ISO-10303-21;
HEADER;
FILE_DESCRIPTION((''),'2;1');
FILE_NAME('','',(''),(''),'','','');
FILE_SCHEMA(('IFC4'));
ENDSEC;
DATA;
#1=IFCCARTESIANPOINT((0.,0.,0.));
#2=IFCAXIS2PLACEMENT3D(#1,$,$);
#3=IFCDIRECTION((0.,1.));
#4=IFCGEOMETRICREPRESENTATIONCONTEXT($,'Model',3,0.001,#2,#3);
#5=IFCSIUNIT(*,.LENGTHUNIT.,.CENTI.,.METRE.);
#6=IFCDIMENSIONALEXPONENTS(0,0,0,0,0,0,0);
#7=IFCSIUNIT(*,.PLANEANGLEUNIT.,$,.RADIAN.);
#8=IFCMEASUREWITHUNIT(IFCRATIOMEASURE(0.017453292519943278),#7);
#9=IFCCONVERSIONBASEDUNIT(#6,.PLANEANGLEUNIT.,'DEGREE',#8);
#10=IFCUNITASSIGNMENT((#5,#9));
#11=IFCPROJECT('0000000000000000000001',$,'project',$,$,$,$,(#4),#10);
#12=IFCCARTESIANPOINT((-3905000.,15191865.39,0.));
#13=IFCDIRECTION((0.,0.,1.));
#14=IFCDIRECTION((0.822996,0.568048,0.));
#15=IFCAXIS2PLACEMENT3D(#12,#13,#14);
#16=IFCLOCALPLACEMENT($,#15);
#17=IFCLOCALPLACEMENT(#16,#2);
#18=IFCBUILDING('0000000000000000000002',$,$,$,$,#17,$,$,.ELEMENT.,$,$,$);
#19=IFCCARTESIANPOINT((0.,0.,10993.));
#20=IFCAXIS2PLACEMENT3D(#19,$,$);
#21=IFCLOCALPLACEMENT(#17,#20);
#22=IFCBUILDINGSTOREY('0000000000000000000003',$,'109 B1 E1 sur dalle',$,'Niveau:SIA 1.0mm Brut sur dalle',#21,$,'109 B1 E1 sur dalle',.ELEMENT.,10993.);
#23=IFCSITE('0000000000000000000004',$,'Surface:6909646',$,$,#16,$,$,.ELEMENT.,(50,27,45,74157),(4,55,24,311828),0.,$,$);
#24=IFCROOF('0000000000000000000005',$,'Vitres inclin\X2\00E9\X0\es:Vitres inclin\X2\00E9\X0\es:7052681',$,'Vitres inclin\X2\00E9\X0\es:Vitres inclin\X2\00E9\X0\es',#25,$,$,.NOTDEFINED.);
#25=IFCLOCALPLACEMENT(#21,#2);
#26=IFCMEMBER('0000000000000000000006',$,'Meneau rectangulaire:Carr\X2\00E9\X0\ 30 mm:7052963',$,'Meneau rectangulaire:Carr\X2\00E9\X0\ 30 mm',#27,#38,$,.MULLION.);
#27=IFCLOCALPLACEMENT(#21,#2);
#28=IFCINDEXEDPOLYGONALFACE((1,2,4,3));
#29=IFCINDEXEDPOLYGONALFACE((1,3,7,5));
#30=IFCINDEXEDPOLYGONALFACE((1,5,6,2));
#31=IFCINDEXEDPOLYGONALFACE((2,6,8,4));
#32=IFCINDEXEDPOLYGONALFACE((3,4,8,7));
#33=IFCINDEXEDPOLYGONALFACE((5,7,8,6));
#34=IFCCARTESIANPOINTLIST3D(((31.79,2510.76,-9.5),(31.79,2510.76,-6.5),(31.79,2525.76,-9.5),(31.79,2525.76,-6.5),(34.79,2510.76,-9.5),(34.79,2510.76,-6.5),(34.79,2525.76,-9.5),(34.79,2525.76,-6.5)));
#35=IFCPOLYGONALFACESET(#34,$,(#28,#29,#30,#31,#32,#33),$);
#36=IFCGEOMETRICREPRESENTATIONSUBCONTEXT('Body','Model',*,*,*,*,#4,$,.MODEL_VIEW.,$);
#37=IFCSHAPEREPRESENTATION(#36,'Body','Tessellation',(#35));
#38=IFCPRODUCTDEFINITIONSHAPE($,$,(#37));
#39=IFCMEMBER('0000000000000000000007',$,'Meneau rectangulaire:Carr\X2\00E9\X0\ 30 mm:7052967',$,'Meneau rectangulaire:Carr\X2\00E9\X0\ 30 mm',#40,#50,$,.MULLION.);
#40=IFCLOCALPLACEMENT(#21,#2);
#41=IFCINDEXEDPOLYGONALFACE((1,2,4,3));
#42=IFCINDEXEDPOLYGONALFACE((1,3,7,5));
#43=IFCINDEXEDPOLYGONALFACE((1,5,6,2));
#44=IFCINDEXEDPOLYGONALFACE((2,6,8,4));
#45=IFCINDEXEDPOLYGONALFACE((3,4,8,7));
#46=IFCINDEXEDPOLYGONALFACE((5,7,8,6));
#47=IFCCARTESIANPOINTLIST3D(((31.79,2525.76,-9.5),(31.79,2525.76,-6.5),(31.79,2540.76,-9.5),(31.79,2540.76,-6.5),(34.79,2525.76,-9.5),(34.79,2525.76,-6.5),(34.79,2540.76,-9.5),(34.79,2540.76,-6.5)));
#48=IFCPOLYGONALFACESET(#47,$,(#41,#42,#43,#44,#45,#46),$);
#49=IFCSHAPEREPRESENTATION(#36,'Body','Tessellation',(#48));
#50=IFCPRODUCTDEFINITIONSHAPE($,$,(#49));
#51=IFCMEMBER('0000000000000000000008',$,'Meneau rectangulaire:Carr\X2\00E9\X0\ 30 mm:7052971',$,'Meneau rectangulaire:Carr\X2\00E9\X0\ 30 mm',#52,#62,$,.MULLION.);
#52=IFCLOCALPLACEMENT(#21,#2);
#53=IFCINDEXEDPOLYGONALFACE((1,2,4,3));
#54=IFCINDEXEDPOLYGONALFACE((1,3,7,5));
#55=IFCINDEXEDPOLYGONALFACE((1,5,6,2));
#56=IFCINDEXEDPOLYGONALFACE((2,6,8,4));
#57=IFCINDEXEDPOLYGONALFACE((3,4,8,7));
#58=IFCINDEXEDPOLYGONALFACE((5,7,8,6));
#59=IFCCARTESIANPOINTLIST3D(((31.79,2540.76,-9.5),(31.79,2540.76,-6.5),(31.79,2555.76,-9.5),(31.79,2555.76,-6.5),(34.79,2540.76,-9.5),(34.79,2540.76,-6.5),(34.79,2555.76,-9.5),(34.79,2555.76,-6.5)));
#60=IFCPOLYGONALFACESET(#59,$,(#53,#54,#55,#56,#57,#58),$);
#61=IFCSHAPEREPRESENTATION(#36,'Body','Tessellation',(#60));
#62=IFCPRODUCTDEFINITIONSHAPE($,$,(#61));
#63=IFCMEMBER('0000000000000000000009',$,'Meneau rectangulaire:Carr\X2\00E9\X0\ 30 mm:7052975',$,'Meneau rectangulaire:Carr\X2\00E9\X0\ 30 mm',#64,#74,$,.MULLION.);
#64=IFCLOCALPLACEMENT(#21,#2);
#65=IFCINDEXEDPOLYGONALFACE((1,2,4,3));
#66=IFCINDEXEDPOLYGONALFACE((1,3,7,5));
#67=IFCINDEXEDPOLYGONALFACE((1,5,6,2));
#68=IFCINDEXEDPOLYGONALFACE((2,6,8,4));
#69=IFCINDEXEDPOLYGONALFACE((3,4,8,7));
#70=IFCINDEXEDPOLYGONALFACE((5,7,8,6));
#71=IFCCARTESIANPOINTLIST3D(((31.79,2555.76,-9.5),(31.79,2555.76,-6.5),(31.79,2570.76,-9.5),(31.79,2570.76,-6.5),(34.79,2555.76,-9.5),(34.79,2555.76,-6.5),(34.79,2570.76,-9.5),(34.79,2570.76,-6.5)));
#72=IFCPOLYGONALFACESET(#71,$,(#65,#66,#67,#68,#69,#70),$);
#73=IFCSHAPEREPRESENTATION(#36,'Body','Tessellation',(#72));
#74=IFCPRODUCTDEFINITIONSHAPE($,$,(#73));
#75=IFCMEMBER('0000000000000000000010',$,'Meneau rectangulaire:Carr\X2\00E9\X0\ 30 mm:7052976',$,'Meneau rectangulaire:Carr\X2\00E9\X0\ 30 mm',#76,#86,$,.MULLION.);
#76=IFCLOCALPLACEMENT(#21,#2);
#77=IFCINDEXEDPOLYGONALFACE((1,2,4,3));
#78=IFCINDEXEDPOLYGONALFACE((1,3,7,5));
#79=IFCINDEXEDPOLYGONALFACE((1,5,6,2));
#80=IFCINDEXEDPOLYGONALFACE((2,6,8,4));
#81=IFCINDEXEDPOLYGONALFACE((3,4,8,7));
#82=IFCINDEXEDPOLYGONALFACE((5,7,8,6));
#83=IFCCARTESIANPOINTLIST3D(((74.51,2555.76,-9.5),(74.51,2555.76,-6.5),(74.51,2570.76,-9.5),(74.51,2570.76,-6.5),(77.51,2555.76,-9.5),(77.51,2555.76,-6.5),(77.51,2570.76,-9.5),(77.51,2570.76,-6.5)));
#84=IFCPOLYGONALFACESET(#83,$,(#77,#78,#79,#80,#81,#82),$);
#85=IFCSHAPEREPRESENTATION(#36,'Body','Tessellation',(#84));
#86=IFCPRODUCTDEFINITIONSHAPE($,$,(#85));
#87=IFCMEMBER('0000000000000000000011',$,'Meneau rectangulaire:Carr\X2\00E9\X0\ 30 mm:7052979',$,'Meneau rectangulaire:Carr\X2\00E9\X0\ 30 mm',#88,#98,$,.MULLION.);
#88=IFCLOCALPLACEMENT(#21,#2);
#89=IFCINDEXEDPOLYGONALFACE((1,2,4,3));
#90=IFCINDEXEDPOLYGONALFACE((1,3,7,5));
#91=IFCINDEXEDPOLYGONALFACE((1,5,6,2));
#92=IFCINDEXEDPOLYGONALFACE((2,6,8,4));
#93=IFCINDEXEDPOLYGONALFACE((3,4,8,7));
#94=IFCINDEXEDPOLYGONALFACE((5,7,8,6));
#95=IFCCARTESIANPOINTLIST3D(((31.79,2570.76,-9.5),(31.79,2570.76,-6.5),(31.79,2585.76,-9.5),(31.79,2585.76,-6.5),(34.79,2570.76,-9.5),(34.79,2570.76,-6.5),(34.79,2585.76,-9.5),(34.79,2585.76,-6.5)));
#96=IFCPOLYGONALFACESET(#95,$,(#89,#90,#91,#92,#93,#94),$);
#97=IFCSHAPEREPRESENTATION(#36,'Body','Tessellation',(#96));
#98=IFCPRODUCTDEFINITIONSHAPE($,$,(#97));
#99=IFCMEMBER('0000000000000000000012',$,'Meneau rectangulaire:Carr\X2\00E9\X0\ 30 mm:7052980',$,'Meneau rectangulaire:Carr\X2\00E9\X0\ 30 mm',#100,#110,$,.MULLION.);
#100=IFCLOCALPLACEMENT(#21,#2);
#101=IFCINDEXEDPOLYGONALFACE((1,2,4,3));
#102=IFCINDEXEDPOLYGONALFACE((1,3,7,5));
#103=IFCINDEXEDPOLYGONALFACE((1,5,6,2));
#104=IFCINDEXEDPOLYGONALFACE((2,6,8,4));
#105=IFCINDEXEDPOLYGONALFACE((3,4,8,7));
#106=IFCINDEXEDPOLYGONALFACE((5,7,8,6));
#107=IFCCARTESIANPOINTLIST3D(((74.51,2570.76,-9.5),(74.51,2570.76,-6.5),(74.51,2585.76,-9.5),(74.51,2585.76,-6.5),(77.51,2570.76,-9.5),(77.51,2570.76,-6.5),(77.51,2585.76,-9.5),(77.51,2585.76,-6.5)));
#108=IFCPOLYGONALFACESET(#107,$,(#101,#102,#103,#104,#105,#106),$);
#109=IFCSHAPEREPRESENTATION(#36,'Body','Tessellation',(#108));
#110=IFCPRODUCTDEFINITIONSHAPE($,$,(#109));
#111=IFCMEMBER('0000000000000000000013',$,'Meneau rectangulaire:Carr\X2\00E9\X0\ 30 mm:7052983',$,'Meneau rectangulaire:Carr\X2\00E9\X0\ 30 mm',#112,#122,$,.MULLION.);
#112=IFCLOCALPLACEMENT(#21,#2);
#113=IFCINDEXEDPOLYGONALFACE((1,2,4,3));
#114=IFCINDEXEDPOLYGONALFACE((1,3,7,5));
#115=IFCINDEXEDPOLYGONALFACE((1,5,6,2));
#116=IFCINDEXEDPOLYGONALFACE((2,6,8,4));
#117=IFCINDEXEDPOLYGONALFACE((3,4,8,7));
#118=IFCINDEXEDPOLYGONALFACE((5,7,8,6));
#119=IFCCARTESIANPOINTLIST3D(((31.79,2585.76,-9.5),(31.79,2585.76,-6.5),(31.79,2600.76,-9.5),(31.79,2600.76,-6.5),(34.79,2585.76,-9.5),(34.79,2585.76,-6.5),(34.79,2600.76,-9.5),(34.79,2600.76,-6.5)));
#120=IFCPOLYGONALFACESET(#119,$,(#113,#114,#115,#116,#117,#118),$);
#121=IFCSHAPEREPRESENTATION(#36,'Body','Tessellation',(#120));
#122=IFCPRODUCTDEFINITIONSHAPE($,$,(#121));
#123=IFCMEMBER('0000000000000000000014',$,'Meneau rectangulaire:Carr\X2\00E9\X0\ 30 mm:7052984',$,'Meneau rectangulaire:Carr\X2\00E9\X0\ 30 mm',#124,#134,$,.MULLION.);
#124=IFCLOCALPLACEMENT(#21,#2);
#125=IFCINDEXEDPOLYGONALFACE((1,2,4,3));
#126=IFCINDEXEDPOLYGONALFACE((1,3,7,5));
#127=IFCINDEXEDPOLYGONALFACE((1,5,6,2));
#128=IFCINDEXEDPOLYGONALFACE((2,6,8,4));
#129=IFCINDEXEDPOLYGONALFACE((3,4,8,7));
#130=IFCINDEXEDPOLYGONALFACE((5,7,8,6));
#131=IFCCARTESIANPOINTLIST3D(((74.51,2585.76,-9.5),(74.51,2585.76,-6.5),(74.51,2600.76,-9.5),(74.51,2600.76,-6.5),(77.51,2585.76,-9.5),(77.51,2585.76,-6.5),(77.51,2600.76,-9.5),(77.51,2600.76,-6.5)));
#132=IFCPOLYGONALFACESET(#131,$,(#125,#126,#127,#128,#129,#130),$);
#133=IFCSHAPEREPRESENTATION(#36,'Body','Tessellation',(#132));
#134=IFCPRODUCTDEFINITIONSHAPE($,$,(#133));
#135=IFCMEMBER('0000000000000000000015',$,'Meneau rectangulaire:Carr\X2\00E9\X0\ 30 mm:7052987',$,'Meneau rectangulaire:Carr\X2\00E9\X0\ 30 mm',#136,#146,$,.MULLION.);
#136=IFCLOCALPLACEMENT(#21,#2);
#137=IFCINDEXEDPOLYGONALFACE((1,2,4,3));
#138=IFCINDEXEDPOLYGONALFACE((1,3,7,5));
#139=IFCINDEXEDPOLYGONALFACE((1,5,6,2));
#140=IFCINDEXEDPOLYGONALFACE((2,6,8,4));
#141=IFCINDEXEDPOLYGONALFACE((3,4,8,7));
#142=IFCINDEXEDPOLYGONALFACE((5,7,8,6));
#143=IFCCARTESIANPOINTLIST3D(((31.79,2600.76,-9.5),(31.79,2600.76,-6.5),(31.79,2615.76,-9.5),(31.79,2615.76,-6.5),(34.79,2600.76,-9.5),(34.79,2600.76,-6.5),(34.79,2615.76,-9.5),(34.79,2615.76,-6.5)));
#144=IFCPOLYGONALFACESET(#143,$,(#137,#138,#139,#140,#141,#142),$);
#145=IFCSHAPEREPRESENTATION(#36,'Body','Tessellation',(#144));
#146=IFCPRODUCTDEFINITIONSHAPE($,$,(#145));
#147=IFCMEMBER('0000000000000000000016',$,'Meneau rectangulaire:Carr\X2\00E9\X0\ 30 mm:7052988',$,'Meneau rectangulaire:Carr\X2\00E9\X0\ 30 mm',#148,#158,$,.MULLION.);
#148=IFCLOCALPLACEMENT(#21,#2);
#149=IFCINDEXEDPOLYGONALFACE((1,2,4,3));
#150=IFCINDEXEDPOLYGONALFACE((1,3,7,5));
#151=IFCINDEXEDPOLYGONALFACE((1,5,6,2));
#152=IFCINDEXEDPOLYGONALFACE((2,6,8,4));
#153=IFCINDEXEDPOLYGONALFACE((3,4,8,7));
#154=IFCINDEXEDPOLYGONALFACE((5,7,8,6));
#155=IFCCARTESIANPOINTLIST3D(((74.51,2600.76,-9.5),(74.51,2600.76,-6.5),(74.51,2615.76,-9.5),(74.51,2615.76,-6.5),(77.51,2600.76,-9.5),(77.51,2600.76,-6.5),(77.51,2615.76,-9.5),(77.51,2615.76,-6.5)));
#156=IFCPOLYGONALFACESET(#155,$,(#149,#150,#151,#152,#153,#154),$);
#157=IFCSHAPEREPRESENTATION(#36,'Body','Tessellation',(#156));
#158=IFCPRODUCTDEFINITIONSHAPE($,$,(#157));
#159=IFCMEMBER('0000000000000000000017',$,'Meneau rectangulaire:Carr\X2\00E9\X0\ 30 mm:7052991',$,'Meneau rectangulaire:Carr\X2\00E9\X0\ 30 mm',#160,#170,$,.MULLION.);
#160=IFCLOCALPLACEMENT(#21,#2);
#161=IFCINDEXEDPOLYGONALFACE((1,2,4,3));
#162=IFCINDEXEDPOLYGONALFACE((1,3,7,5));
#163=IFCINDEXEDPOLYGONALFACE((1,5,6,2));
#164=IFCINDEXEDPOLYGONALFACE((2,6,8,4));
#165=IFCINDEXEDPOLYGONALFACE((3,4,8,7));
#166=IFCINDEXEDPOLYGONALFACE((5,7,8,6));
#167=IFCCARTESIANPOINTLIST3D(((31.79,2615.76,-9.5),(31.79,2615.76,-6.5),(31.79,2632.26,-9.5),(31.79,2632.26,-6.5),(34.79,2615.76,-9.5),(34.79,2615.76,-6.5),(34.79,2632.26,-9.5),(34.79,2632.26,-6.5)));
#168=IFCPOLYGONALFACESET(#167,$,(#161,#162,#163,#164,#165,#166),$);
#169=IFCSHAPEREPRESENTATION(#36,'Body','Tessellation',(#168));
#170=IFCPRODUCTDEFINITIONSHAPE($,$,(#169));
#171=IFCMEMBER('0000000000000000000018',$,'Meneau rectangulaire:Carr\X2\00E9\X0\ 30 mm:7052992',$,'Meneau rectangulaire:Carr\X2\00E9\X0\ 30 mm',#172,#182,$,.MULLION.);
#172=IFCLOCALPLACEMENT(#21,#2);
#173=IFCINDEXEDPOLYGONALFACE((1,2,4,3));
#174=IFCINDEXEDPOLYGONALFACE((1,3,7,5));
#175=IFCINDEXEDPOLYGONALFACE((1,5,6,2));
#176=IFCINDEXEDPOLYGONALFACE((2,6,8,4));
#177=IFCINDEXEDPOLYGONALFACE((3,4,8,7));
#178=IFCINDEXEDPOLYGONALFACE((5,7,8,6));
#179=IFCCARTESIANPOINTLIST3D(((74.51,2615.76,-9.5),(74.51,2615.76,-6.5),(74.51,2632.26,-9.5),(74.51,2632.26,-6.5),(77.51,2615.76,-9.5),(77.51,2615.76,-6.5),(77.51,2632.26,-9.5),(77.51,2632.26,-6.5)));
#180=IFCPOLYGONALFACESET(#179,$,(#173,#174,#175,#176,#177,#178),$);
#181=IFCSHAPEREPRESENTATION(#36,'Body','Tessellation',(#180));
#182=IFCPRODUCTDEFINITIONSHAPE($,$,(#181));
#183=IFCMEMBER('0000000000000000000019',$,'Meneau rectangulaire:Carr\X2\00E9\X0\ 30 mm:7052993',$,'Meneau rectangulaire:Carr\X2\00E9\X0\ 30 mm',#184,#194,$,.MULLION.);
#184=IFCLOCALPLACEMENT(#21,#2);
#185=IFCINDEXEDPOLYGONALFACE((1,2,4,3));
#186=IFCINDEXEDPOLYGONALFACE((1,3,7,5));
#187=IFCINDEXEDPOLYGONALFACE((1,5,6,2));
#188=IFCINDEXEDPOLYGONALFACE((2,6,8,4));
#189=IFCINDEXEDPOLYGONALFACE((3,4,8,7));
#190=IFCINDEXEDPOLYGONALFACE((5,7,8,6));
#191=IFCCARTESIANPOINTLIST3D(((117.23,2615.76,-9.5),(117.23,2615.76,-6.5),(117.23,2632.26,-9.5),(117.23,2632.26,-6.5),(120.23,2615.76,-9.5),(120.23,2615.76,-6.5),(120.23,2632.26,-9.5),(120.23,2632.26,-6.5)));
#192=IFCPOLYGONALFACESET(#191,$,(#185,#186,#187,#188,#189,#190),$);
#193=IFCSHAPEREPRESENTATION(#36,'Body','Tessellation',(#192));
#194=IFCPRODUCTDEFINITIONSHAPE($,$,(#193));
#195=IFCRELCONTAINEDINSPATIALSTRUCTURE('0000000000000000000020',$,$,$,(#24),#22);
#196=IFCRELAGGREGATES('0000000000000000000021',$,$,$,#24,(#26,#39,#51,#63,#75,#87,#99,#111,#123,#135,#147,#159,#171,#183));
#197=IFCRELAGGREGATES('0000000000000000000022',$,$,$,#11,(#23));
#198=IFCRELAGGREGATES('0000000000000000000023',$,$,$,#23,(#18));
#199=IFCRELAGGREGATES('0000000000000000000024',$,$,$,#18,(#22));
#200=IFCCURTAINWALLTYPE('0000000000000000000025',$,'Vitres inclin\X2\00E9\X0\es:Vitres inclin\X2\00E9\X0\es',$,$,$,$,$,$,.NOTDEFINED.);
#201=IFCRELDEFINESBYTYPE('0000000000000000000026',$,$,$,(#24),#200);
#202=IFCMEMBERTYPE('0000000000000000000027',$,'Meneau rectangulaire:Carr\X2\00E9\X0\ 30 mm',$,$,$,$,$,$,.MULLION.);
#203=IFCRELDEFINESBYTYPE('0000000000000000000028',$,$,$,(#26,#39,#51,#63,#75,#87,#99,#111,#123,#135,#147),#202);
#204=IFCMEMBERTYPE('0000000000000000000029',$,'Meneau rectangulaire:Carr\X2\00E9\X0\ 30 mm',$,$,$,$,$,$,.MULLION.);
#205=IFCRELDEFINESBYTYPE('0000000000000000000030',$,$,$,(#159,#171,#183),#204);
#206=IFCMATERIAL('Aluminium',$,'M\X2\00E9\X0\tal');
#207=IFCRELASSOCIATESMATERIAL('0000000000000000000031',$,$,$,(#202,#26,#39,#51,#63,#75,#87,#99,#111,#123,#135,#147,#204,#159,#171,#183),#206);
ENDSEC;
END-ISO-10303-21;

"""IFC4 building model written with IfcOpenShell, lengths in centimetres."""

from ifc_helpers import new_model, entity, si_unit, converted_unit, direction, frame, origin, place, context, subcontext, project, spatial, indexed_curve, outline, extrude, source, transform, mapped, material, type_object, type_shapes, element, aggregate, save


model = new_model("IFC4")

# Units and contexts
model_context = context("Model", 3, precision=0.001, world=origin(), true_north=direction((0.0, 1.0)))
body_context = subcontext(model_context, "Body", "Model", "MODEL_VIEW")
ifc_project = project(units=[si_unit("LENGTHUNIT", "METRE", prefix="CENTI"), converted_unit("PLANEANGLEUNIT", "DEGREE", entity("IfcRatioMeasure", 0.017453292519943278), si_unit("PLANEANGLEUNIT", "RADIAN"), dimensions=[0, 0, 0, 0, 0, 0, 0])], contexts=[model_context])

# Site, building, storey
site_placement = place(None, frame((-3905000.0, 15191865.39, 0.0), z_axis=(0.0, 0.0, 1.0), x_axis=(0.822996, 0.568048, 0.0)))
site = spatial("IfcSite", under=ifc_project, at=site_placement, Name="Surface:6909646", CompositionType="ELEMENT", RefLatitude=(50, 27, 45, 74157), RefLongitude=(4, 55, 24, 311828), RefElevation=0.0)
building_placement = place(site_placement, origin())
building = spatial("IfcBuilding", under=site, at=building_placement, CompositionType="ELEMENT")
storey_placement = place(building_placement, frame((0.0, 0.0, 10993.0)))
storey = spatial("IfcBuildingStorey", under=building, at=storey_placement, Name="109 B1 E1 sur dalle", ObjectType="Niveau:SIA 1.0mm Brut sur dalle", LongName="109 B1 E1 sur dalle", CompositionType="ELEMENT", Elevation=10993.0)

# Roof, members
curtain_wall_type = type_object("IfcCurtainWallType", Name="Vitres inclinées:Vitres inclinées", PredefinedType="NOTDEFINED")
roof_placement = place(storey_placement, frame((0.0, 0.0, -10993.0)))
roof = element("IfcRoof", 1, at=roof_placement, inside=storey, type_object=curtain_wall_type, Name="Vitres inclinées:Vitres inclinées:7052681", ObjectType="Vitres inclinées:Vitres inclinées", PredefinedType="NOTDEFINED")
ifc_material = material(Name="Aluminium", Category="Métal")
member_type_1 = type_object("IfcMemberType", Name="Meneau rectangulaire:Carré 30 mm", PredefinedType="MULLION", material=ifc_material)
shared_shape_1 = source(origin(), body_context, "Body", "SweptSolid", [
    extrude(outline(indexed_curve([(-1.5, -1.5), (1.5, -1.5), (1.5, 1.5), (-1.5, 1.5), (-1.5, -1.5)], self_intersect=False)), frame((0.0, 0.0, -15.0), z_axis=(0.0, 0.0, 1.0), x_axis=(0.0, -1.0, 0.0)), (0.0, 0.0, 1.0), 15.0),
])
type_shapes(member_type_1, [shared_shape_1])
member_1_placement = place(roof_placement, frame((33.29, 2525.76, 10985.0), z_axis=(0.0, 1.0, 0.0), x_axis=(1.0, 0.0, 0.0)))
member_1 = element("IfcMember", 2, at=member_1_placement, type_object=member_type_1, material=ifc_material, Name="Meneau rectangulaire:Carré 30 mm:7052963", ObjectType="Meneau rectangulaire:Carré 30 mm", PredefinedType="MULLION", context=body_context, shape_type="MappedRepresentation", body=[
    mapped(shared_shape_1, transform((0.0, 0.0, 0.0), scale=1.0)),
])
member_2_placement = place(roof_placement, frame((33.29, 2540.76, 10985.0), z_axis=(0.0, 1.0, 0.0), x_axis=(1.0, 0.0, 0.0)))
member_2 = element("IfcMember", 3, at=member_2_placement, type_object=member_type_1, material=ifc_material, Name="Meneau rectangulaire:Carré 30 mm:7052967", ObjectType="Meneau rectangulaire:Carré 30 mm", PredefinedType="MULLION", context=body_context, shape_type="MappedRepresentation", body=[
    mapped(shared_shape_1, transform((0.0, 0.0, 0.0), scale=1.0)),
])
member_3_placement = place(roof_placement, frame((33.29, 2555.76, 10985.0), z_axis=(0.0, 1.0, 0.0), x_axis=(1.0, 0.0, 0.0)))
member_3 = element("IfcMember", 4, at=member_3_placement, type_object=member_type_1, material=ifc_material, Name="Meneau rectangulaire:Carré 30 mm:7052971", ObjectType="Meneau rectangulaire:Carré 30 mm", PredefinedType="MULLION", context=body_context, shape_type="MappedRepresentation", body=[
    mapped(shared_shape_1, transform((0.0, 0.0, 0.0), scale=1.0)),
])
member_4_placement = place(roof_placement, frame((33.29, 2570.76, 10985.0), z_axis=(0.0, 1.0, 0.0), x_axis=(1.0, 0.0, 0.0)))
member_4 = element("IfcMember", 5, at=member_4_placement, type_object=member_type_1, material=ifc_material, Name="Meneau rectangulaire:Carré 30 mm:7052975", ObjectType="Meneau rectangulaire:Carré 30 mm", PredefinedType="MULLION", context=body_context, shape_type="MappedRepresentation", body=[
    mapped(shared_shape_1, transform((0.0, 0.0, 0.0), scale=1.0)),
])
member_5_placement = place(roof_placement, frame((76.01, 2570.76, 10985.0), z_axis=(0.0, 1.0, 0.0), x_axis=(1.0, 0.0, 0.0)))
member_5 = element("IfcMember", 6, at=member_5_placement, type_object=member_type_1, material=ifc_material, Name="Meneau rectangulaire:Carré 30 mm:7052976", ObjectType="Meneau rectangulaire:Carré 30 mm", PredefinedType="MULLION", context=body_context, shape_type="MappedRepresentation", body=[
    mapped(shared_shape_1, transform((0.0, 0.0, 0.0), scale=1.0)),
])
member_6_placement = place(roof_placement, frame((33.29, 2585.76, 10985.0), z_axis=(0.0, 1.0, 0.0), x_axis=(1.0, 0.0, 0.0)))
member_6 = element("IfcMember", 7, at=member_6_placement, type_object=member_type_1, material=ifc_material, Name="Meneau rectangulaire:Carré 30 mm:7052979", ObjectType="Meneau rectangulaire:Carré 30 mm", PredefinedType="MULLION", context=body_context, shape_type="MappedRepresentation", body=[
    mapped(shared_shape_1, transform((0.0, 0.0, 0.0), scale=1.0)),
])
member_7_placement = place(roof_placement, frame((76.01, 2585.76, 10985.0), z_axis=(0.0, 1.0, 0.0), x_axis=(1.0, 0.0, 0.0)))
member_7 = element("IfcMember", 8, at=member_7_placement, type_object=member_type_1, material=ifc_material, Name="Meneau rectangulaire:Carré 30 mm:7052980", ObjectType="Meneau rectangulaire:Carré 30 mm", PredefinedType="MULLION", context=body_context, shape_type="MappedRepresentation", body=[
    mapped(shared_shape_1, transform((0.0, 0.0, 0.0), scale=1.0)),
])
member_8_placement = place(roof_placement, frame((33.29, 2600.76, 10985.0), z_axis=(0.0, 1.0, 0.0), x_axis=(1.0, 0.0, 0.0)))
member_8 = element("IfcMember", 9, at=member_8_placement, type_object=member_type_1, material=ifc_material, Name="Meneau rectangulaire:Carré 30 mm:7052983", ObjectType="Meneau rectangulaire:Carré 30 mm", PredefinedType="MULLION", context=body_context, shape_type="MappedRepresentation", body=[
    mapped(shared_shape_1, transform((0.0, 0.0, 0.0), scale=1.0)),
])
member_9_placement = place(roof_placement, frame((76.01, 2600.76, 10985.0), z_axis=(0.0, 1.0, 0.0), x_axis=(1.0, 0.0, 0.0)))
member_9 = element("IfcMember", 10, at=member_9_placement, type_object=member_type_1, material=ifc_material, Name="Meneau rectangulaire:Carré 30 mm:7052984", ObjectType="Meneau rectangulaire:Carré 30 mm", PredefinedType="MULLION", context=body_context, shape_type="MappedRepresentation", body=[
    mapped(shared_shape_1, transform((0.0, 0.0, 0.0), scale=1.0)),
])
member_10_placement = place(roof_placement, frame((33.29, 2615.76, 10985.0), z_axis=(0.0, 1.0, 0.0), x_axis=(1.0, 0.0, 0.0)))
member_10 = element("IfcMember", 11, at=member_10_placement, type_object=member_type_1, material=ifc_material, Name="Meneau rectangulaire:Carré 30 mm:7052987", ObjectType="Meneau rectangulaire:Carré 30 mm", PredefinedType="MULLION", context=body_context, shape_type="MappedRepresentation", body=[
    mapped(shared_shape_1, transform((0.0, 0.0, 0.0), scale=1.0)),
])
member_11_placement = place(roof_placement, frame((76.01, 2615.76, 10985.0), z_axis=(0.0, 1.0, 0.0), x_axis=(1.0, 0.0, 0.0)))
member_11 = element("IfcMember", 12, at=member_11_placement, type_object=member_type_1, material=ifc_material, Name="Meneau rectangulaire:Carré 30 mm:7052988", ObjectType="Meneau rectangulaire:Carré 30 mm", PredefinedType="MULLION", context=body_context, shape_type="MappedRepresentation", body=[
    mapped(shared_shape_1, transform((0.0, 0.0, 0.0), scale=1.0)),
])
member_type_2 = type_object("IfcMemberType", Name="Meneau rectangulaire:Carré 30 mm", PredefinedType="MULLION", material=ifc_material)
shared_shape_2 = source(origin(), body_context, "Body", "SweptSolid", [
    extrude(outline(indexed_curve([(-1.5, -1.5), (1.5, -1.5), (1.5, 1.5), (-1.5, 1.5), (-1.5, -1.5)], self_intersect=False)), frame((0.0, 0.0, -16.5), z_axis=(0.0, 0.0, 1.0), x_axis=(0.0, -1.0, 0.0)), (0.0, 0.0, 1.0), 16.5),
])
type_shapes(member_type_2, [shared_shape_2])
member_12_placement = place(roof_placement, frame((33.29, 2632.26, 10985.0), z_axis=(0.0, 1.0, 0.0), x_axis=(1.0, 0.0, 0.0)))
member_12 = element("IfcMember", 13, at=member_12_placement, type_object=member_type_2, material=ifc_material, Name="Meneau rectangulaire:Carré 30 mm:7052991", ObjectType="Meneau rectangulaire:Carré 30 mm", PredefinedType="MULLION", context=body_context, shape_type="MappedRepresentation", body=[
    mapped(shared_shape_2, transform((0.0, 0.0, 0.0), scale=1.0)),
])
member_13_placement = place(roof_placement, frame((76.01, 2632.26, 10985.0), z_axis=(0.0, 1.0, 0.0), x_axis=(1.0, 0.0, 0.0)))
member_13 = element("IfcMember", 14, at=member_13_placement, type_object=member_type_2, material=ifc_material, Name="Meneau rectangulaire:Carré 30 mm:7052992", ObjectType="Meneau rectangulaire:Carré 30 mm", PredefinedType="MULLION", context=body_context, shape_type="MappedRepresentation", body=[
    mapped(shared_shape_2, transform((0.0, 0.0, 0.0), scale=1.0)),
])
member_14_placement = place(roof_placement, frame((118.73, 2632.26, 10985.0), z_axis=(0.0, 1.0, 0.0), x_axis=(1.0, 0.0, 0.0)))
member_14 = element("IfcMember", 15, at=member_14_placement, type_object=member_type_2, material=ifc_material, Name="Meneau rectangulaire:Carré 30 mm:7052993", ObjectType="Meneau rectangulaire:Carré 30 mm", PredefinedType="MULLION", context=body_context, shape_type="MappedRepresentation", body=[
    mapped(shared_shape_2, transform((0.0, 0.0, 0.0), scale=1.0)),
])
aggregate(roof, [member_1, member_2, member_3, member_4, member_5, member_6, member_7, member_8, member_9, member_10, member_11, member_12, member_13, member_14])

save(model, "model.ifc")
